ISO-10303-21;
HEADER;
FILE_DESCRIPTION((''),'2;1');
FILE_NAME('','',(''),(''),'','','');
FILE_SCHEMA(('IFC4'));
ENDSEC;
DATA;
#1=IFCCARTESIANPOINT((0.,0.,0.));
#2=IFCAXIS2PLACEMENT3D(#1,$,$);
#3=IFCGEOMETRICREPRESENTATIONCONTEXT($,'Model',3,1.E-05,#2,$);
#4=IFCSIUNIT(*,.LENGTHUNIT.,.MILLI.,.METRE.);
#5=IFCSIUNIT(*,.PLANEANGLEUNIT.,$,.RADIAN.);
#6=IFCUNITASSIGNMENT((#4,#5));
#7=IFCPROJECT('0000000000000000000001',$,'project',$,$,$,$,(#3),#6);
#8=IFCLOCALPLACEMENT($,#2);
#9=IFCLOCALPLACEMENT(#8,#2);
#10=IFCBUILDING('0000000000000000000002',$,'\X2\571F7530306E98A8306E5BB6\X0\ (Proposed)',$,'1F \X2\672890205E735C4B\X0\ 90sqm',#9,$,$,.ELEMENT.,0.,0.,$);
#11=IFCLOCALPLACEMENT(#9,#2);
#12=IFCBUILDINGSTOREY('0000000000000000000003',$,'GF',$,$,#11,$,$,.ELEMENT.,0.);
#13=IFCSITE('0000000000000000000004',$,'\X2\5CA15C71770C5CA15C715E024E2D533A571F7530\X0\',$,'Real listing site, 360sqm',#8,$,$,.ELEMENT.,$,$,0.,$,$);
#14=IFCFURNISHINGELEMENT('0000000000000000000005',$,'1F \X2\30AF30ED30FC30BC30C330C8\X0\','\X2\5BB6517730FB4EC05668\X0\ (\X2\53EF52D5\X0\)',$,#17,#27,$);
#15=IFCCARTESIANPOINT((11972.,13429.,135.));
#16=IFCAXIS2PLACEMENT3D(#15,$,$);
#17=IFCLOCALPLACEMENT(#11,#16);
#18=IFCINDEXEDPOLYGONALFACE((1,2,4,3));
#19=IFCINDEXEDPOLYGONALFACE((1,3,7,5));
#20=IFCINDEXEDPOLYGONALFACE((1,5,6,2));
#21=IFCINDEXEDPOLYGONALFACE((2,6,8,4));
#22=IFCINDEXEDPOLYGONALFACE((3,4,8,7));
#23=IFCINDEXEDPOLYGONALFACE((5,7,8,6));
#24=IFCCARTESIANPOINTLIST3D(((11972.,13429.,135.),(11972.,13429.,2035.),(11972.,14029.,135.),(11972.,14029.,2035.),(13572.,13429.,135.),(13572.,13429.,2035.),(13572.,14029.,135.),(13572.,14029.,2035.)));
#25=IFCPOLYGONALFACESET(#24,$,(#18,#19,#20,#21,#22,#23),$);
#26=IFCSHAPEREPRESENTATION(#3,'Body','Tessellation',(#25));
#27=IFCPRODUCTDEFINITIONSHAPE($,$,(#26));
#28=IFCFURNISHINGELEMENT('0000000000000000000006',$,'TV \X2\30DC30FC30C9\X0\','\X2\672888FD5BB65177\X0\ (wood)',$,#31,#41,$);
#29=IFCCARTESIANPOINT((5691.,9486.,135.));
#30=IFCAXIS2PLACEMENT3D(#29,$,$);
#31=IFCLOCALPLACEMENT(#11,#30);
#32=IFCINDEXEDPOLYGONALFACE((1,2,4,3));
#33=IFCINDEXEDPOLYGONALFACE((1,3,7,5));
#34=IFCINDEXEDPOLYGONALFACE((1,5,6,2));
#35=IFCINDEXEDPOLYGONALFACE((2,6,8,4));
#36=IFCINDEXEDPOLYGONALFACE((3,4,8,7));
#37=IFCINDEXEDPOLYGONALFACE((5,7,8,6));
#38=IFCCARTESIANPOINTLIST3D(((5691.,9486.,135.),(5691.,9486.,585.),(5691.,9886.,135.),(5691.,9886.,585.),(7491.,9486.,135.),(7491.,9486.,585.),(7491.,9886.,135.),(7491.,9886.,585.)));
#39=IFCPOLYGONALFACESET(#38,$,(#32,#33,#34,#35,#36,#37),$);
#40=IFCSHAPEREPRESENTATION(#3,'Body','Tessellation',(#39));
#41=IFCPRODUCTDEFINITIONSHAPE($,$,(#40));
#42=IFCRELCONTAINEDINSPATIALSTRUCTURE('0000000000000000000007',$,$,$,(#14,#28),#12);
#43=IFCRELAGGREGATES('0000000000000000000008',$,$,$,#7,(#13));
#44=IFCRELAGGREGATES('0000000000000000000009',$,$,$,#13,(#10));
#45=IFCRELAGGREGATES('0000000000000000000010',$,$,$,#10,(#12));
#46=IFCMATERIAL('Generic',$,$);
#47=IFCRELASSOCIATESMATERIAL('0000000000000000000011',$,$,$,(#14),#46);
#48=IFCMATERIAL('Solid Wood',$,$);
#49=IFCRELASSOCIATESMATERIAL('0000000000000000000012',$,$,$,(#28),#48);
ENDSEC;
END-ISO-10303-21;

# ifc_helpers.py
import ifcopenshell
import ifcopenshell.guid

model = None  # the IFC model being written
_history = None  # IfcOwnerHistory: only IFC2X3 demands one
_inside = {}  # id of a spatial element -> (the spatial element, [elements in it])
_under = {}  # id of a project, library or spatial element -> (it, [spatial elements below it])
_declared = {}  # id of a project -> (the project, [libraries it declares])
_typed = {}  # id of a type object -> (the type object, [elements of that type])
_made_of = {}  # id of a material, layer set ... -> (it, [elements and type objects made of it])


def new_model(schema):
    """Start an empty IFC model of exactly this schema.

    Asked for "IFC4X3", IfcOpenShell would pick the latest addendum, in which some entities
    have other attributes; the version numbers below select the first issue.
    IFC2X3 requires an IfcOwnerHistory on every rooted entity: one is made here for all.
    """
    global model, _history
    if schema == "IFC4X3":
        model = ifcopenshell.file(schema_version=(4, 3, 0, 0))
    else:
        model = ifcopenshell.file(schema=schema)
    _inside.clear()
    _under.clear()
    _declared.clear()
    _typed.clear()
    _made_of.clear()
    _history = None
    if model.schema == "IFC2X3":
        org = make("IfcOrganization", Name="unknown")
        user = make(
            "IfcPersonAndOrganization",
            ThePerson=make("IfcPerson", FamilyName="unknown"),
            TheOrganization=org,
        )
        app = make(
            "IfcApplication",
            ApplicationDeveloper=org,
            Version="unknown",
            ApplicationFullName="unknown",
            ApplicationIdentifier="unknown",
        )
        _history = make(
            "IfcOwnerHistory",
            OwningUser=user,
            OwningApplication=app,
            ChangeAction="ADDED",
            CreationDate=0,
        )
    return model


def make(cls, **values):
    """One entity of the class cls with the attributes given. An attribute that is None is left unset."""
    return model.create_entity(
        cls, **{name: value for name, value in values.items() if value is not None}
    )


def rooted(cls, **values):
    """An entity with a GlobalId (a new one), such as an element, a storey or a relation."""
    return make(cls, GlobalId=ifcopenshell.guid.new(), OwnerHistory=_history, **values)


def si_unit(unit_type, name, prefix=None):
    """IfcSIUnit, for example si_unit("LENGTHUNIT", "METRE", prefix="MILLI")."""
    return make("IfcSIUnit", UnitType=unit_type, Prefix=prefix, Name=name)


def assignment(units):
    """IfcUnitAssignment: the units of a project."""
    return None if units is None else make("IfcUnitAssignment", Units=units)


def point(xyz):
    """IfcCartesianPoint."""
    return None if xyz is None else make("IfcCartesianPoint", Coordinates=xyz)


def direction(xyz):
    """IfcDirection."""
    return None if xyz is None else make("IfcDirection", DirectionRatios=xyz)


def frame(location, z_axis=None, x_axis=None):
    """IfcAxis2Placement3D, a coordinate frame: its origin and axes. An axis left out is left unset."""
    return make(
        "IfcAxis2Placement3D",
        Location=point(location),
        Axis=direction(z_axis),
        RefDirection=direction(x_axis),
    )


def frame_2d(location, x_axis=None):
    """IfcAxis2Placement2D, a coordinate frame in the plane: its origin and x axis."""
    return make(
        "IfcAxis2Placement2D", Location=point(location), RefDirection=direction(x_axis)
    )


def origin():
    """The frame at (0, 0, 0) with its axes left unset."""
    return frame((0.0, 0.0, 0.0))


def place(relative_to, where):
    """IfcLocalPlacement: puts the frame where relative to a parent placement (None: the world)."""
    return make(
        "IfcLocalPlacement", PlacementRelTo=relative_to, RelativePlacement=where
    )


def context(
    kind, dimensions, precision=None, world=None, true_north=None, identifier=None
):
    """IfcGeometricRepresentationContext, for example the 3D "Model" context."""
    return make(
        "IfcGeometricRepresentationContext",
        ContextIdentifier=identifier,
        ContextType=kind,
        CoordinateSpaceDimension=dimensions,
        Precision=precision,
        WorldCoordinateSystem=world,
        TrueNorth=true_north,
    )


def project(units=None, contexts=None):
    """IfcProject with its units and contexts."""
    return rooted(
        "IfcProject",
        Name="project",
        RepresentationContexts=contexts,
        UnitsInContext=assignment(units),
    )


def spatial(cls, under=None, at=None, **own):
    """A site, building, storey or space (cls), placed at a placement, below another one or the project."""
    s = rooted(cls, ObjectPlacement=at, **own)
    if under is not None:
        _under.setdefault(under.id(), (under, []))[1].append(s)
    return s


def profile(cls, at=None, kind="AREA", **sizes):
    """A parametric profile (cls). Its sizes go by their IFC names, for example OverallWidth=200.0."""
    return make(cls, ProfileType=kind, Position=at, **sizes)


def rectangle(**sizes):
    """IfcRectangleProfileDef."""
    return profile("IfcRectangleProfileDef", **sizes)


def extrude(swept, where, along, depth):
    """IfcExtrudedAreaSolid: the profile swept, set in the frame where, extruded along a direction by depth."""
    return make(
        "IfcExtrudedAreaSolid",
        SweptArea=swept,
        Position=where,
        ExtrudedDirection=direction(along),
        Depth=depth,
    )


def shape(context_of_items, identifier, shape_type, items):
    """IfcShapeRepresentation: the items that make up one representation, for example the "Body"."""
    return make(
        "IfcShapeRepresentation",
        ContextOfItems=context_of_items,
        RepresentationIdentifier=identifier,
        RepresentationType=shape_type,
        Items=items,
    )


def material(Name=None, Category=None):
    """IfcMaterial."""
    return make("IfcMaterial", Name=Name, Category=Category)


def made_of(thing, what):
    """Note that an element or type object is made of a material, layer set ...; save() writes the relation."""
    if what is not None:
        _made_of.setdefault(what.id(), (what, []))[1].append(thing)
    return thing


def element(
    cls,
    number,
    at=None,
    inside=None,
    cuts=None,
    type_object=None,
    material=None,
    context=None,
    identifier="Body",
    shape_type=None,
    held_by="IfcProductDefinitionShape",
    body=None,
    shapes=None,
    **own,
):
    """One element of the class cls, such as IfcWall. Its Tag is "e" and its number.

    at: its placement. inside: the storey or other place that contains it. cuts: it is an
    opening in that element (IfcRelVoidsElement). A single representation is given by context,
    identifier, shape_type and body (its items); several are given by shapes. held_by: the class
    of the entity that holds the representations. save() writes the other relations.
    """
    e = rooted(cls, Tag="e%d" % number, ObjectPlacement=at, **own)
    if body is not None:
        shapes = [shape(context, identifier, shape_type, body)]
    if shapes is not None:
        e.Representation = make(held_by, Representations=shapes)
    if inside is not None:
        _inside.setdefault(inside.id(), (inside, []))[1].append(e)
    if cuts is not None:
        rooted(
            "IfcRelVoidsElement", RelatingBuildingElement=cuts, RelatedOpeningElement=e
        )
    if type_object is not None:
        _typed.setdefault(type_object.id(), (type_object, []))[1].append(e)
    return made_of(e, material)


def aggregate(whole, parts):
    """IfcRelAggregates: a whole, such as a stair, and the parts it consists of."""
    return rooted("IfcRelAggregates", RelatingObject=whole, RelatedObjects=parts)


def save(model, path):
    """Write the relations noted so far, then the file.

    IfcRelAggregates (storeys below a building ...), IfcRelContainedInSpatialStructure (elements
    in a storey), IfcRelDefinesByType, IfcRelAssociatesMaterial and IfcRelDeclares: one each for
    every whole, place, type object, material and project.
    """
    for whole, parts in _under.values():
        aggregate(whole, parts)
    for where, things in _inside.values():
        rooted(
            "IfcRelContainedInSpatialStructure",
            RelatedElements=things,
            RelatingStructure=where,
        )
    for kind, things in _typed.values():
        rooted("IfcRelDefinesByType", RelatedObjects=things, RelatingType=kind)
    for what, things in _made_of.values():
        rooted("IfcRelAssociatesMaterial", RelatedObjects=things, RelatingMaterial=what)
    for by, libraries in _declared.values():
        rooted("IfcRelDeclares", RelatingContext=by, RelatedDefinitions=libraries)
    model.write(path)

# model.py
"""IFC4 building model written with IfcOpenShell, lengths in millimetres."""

from ifc_helpers import new_model, si_unit, frame, frame_2d, origin, place, context, project, spatial, rectangle, extrude, material, element, save


model = new_model("IFC4")

# Units and contexts
model_context = context("Model", 3, precision=1e-05, world=origin())
ifc_project = project(units=[si_unit("LENGTHUNIT", "METRE", prefix="MILLI"), si_unit("PLANEANGLEUNIT", "RADIAN")], contexts=[model_context])

# Site, building, storey
site_placement = place(None, origin())
site = spatial("IfcSite", under=ifc_project, at=site_placement, Name="岡山県岡山市中区土田", ObjectType="Real listing site, 360sqm", CompositionType="ELEMENT", RefElevation=0.0)
building_placement = place(site_placement, origin())
building = spatial("IfcBuilding", under=site, at=building_placement, Name="土田の風の家 (Proposed)", ObjectType="1F 木造平屋 90sqm", CompositionType="ELEMENT", ElevationOfRefHeight=0.0, ElevationOfTerrain=0.0)
storey_placement = place(building_placement, origin())
storey = spatial("IfcBuildingStorey", under=building, at=storey_placement, Name="GF", CompositionType="ELEMENT", Elevation=0.0)

# Shared definitions
ifc_material_1 = material(Name="Solid Wood")

# Shared definitions
ifc_material_2 = material(Name="Generic")

# Furnishing elements
furnishing_1_placement = place(storey_placement, frame((11972.0, 13429.0, 135.0)))
element("IfcFurnishingElement", 1, at=furnishing_1_placement, inside=storey, material=ifc_material_2, Name="1F クローゼット", Description="家具・什器 (可動)", context=model_context, shape_type="SweptSolid", body=[
    extrude(rectangle(XDim=1600.0, YDim=600.0, at=frame_2d((800.0, 300.0))), frame((11972.0, 13429.0, 135.0)), (0.0, 0.0, 1.0), 1900.0),
])
furnishing_2_placement = place(storey_placement, frame((5691.0, 9486.0, 135.0)))
element("IfcFurnishingElement", 2, at=furnishing_2_placement, inside=storey, material=ifc_material_1, Name="TV ボード", Description="木製家具 (wood)", context=model_context, shape_type="SweptSolid", body=[
    extrude(rectangle(XDim=1800.0, YDim=400.0, at=frame_2d((900.0, 200.0))), frame((5691.0, 9486.0, 135.0)), (0.0, 0.0, 1.0), 450.0),
])

save(model, "model.ifc")
